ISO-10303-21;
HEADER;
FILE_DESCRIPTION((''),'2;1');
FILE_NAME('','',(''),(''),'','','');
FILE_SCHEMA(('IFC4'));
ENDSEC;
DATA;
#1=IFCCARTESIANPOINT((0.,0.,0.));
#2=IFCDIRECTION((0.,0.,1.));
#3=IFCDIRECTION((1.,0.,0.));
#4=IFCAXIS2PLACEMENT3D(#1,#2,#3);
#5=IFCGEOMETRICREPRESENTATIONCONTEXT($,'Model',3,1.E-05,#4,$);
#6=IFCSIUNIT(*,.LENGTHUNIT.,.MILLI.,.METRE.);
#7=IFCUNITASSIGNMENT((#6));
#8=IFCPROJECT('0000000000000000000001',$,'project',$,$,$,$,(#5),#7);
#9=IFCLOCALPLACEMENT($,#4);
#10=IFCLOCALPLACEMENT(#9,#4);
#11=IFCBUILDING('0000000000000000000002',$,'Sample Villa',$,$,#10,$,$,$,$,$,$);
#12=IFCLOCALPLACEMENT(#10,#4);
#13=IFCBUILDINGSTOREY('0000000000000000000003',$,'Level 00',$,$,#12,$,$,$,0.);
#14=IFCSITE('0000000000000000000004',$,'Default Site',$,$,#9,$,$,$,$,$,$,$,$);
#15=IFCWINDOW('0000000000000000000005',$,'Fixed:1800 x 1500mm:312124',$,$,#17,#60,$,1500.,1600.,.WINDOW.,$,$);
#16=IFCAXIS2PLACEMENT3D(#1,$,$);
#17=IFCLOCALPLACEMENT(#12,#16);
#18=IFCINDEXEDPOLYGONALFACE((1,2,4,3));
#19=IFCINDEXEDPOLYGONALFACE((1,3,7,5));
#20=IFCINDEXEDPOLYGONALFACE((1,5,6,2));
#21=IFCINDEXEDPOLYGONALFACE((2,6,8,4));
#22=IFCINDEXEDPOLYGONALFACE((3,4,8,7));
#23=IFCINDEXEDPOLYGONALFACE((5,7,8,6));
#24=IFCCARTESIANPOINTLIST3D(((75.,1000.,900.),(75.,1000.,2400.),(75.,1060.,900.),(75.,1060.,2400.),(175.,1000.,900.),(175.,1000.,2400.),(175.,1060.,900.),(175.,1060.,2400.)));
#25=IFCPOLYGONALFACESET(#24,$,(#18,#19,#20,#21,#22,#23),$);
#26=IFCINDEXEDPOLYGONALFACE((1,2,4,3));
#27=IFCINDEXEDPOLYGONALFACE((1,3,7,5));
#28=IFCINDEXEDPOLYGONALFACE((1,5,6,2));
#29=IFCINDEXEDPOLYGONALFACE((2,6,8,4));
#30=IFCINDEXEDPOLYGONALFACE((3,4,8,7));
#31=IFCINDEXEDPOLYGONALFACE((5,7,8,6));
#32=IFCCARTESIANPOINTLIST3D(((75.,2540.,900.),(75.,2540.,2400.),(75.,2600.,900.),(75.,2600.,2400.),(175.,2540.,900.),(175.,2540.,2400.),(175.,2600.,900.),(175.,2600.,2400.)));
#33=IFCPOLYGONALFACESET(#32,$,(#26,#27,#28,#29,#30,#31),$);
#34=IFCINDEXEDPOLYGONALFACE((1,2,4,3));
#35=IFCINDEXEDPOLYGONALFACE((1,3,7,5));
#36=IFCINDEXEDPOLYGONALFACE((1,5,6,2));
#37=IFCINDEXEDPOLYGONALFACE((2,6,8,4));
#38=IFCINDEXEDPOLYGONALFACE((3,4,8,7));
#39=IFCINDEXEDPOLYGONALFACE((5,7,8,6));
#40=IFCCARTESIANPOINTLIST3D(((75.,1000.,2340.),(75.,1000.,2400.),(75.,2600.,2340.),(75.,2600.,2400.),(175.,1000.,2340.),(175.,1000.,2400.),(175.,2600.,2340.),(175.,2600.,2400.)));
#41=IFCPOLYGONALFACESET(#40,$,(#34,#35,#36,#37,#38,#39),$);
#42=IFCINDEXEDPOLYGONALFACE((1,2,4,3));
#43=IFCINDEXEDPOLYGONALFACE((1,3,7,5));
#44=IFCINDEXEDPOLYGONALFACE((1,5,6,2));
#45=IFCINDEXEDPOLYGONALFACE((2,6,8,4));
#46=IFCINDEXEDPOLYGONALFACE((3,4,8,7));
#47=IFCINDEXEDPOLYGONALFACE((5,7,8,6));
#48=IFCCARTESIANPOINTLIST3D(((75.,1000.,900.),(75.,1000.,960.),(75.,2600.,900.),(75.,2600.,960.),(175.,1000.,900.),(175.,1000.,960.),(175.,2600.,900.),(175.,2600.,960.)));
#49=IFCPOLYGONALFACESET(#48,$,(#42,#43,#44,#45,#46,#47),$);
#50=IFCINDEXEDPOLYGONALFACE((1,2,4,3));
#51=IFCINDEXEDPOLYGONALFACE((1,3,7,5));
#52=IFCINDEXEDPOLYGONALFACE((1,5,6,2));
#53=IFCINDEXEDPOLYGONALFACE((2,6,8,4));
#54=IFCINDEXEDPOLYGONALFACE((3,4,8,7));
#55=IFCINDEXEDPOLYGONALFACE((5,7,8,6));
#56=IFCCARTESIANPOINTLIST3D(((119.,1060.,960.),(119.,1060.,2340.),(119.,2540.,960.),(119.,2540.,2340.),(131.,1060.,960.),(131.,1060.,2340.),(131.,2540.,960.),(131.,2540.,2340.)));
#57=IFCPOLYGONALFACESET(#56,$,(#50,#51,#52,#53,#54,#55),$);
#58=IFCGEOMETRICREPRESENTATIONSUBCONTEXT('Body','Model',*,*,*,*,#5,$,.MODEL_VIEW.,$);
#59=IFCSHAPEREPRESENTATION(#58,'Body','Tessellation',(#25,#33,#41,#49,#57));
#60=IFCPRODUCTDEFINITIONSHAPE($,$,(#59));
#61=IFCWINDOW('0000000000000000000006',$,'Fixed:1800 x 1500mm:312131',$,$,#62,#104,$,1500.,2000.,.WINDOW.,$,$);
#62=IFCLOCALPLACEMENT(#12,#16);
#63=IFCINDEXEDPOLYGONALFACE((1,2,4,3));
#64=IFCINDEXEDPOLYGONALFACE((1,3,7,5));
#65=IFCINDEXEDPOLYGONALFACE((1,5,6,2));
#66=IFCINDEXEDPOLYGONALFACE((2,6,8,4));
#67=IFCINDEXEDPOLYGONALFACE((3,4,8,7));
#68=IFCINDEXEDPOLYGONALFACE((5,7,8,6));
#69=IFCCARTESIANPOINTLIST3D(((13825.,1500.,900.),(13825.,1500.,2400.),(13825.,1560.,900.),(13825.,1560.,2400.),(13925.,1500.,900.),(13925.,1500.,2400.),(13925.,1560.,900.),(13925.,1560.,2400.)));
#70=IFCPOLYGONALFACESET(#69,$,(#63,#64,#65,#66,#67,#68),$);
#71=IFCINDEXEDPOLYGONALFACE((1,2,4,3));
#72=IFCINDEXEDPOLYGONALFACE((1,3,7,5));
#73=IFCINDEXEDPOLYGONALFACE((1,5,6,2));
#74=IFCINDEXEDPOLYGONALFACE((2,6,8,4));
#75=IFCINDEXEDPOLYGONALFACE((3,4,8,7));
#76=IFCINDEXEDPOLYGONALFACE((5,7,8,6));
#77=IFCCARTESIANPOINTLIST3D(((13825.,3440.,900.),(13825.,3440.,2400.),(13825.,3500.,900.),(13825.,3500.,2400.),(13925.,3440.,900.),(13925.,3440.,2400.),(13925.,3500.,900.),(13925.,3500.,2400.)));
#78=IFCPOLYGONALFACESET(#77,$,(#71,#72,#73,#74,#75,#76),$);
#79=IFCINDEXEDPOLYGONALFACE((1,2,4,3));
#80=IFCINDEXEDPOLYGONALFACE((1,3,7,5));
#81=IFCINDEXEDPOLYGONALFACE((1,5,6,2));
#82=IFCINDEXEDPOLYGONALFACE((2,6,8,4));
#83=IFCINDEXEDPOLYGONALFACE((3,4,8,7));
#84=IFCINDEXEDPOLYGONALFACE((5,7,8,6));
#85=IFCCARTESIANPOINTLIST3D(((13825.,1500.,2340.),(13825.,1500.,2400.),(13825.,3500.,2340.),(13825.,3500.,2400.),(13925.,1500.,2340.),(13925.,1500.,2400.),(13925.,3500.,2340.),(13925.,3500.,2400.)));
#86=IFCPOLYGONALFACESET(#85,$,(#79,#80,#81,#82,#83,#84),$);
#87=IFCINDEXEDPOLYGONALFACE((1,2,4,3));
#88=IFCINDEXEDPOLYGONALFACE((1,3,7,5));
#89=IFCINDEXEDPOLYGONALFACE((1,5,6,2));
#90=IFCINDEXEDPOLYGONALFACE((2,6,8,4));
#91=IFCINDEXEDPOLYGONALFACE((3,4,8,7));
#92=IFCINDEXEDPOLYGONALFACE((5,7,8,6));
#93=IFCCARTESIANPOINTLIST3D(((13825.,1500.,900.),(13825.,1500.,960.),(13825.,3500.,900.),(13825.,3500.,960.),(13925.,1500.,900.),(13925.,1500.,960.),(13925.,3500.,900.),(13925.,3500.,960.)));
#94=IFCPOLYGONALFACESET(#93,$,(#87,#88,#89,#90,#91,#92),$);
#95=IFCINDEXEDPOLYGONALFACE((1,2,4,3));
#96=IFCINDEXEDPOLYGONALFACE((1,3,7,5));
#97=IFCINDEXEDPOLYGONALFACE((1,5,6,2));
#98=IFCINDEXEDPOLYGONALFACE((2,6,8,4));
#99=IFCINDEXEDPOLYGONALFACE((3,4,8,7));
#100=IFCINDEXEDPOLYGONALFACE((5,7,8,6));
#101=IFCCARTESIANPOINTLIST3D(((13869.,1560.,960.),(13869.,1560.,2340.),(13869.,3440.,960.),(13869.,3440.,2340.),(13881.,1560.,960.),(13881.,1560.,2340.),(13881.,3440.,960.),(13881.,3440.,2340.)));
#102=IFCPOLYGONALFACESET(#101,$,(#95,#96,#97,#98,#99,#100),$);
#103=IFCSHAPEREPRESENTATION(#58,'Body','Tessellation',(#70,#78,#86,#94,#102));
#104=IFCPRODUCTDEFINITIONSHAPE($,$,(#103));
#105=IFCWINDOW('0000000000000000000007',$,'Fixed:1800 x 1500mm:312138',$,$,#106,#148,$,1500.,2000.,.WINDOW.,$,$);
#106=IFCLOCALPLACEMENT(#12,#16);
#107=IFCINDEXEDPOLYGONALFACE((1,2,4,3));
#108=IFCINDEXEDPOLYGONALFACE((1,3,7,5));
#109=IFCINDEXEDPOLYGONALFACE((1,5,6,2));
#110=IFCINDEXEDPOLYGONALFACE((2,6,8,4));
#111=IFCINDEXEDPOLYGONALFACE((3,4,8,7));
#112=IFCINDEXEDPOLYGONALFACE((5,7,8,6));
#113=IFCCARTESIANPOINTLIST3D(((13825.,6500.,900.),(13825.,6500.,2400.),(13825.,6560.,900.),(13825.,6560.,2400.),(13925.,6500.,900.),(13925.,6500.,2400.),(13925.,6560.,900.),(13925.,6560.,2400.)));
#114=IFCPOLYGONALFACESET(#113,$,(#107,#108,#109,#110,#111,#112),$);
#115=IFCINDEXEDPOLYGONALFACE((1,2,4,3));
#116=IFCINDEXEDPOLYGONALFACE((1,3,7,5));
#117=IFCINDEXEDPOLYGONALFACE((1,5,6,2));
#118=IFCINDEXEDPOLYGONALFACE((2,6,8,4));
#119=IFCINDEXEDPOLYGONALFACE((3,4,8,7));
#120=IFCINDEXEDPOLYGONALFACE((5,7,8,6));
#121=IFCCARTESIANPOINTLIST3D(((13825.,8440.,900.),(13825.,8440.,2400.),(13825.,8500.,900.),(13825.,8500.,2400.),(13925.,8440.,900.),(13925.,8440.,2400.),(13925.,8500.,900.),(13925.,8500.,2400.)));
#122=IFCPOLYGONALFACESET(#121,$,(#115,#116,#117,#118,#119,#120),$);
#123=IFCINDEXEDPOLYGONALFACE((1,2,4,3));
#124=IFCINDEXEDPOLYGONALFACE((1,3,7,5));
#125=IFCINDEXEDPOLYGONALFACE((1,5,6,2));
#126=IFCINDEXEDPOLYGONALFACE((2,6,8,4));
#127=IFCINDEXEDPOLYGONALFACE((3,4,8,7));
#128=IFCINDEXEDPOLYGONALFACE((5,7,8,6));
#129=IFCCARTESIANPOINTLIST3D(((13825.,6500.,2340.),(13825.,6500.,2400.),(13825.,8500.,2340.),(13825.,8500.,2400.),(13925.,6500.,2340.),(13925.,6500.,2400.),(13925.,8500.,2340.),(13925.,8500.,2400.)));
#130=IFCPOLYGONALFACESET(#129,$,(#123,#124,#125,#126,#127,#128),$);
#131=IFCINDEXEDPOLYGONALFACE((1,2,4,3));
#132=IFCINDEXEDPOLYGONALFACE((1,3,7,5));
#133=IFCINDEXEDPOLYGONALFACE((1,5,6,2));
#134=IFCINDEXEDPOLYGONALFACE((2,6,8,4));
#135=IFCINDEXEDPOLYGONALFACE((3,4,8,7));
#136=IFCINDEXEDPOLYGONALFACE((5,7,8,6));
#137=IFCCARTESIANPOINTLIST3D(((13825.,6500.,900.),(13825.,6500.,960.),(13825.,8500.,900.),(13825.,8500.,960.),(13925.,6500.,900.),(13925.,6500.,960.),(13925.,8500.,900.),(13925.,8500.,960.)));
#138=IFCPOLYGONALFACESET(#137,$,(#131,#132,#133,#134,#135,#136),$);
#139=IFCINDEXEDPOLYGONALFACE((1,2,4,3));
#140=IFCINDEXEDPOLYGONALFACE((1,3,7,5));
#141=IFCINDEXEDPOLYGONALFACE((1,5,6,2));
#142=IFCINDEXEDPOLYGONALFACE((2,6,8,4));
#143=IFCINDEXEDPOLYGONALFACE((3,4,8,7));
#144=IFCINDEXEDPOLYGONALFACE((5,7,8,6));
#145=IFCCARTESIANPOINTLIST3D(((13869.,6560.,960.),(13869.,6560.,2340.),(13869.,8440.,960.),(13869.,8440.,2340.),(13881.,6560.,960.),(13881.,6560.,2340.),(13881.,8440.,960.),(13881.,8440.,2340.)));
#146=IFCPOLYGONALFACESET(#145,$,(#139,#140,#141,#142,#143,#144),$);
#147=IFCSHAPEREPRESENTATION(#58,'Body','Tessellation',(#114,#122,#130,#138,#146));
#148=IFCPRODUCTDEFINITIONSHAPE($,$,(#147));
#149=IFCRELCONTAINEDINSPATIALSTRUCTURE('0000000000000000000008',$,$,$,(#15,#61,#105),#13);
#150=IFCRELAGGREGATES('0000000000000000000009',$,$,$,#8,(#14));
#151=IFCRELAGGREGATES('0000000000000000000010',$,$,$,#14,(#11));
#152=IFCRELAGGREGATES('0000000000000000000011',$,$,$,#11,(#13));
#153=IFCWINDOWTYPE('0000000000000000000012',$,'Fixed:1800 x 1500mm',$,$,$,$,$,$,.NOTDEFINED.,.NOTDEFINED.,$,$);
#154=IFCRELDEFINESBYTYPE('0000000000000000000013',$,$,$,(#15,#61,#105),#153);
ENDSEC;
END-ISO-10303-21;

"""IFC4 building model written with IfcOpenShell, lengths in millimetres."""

from ifc_helpers import new_model, si_unit, frame, frame_2d, origin_with_axes, place, context, subcontext, project, spatial, rectangle, extrude, type_object, element, save


model = new_model("IFC4")

# Units and contexts
model_context = context("Model", 3, precision=1e-05, world=origin_with_axes())
body_context = subcontext(model_context, "Body", "Model", "MODEL_VIEW")
ifc_project = project(units=[si_unit("LENGTHUNIT", "METRE", prefix="MILLI")], contexts=[model_context])

# Site, building, storey
site_placement = place(None, origin_with_axes())
site = spatial("IfcSite", under=ifc_project, at=site_placement, Name="Default Site")
building_placement = place(site_placement, origin_with_axes())
building = spatial("IfcBuilding", under=site, at=building_placement, Name="Sample Villa")
storey_placement = place(building_placement, origin_with_axes())
storey = spatial("IfcBuildingStorey", under=building, at=storey_placement, Name="Level 00", Elevation=0.0)

# Windows
window_type = type_object("IfcWindowType", Name="Fixed:1800 x 1500mm", PartitioningType="NOTDEFINED", PredefinedType="NOTDEFINED")
window_1_placement = place(storey_placement, origin_with_axes())
element("IfcWindow", 1, at=window_1_placement, inside=storey, type_object=window_type, Name="Fixed:1800 x 1500mm:312124", OverallHeight=1500.0, OverallWidth=1600.0, PredefinedType="WINDOW", context=body_context, shape_type="SweptSolid", body=[
    extrude(rectangle(XDim=100.0, YDim=60.0, at=frame_2d((50.0, 30.0))), frame((75.0, 1000.0, 900.0)), (0.0, 0.0, 1.0), 1500.0),
    extrude(rectangle(XDim=100.0, YDim=60.0, at=frame_2d((50.0, 30.0))), frame((75.0, 2540.0, 900.0)), (0.0, 0.0, 1.0), 1500.0),
    extrude(rectangle(XDim=100.0, YDim=1600.0, at=frame_2d((50.0, 800.0))), frame((75.0, 1000.0, 2340.0)), (0.0, 0.0, 1.0), 60.0),
    extrude(rectangle(XDim=100.0, YDim=1600.0, at=frame_2d((50.0, 800.0))), frame((75.0, 1000.0, 900.0)), (0.0, 0.0, 1.0), 60.0),
    extrude(rectangle(XDim=12.0, YDim=1480.0, at=frame_2d((6.0, 740.0))), frame((119.0, 1060.0, 960.0)), (0.0, 0.0, 1.0), 1380.0),
])
window_2_placement = place(storey_placement, origin_with_axes())
element("IfcWindow", 2, at=window_2_placement, inside=storey, type_object=window_type, Name="Fixed:1800 x 1500mm:312131", OverallHeight=1500.0, OverallWidth=2000.0, PredefinedType="WINDOW", context=body_context, shape_type="SweptSolid", body=[
    extrude(rectangle(XDim=100.0, YDim=60.0, at=frame_2d((50.0, 30.0))), frame((13825.0, 1500.0, 900.0)), (0.0, 0.0, 1.0), 1500.0),
    extrude(rectangle(XDim=100.0, YDim=60.0, at=frame_2d((50.0, 30.0))), frame((13825.0, 3440.0, 900.0)), (0.0, 0.0, 1.0), 1500.0),
    extrude(rectangle(XDim=100.0, YDim=2000.0, at=frame_2d((50.0, 1000.0))), frame((13825.0, 1500.0, 2340.0)), (0.0, 0.0, 1.0), 60.0),
    extrude(rectangle(XDim=100.0, YDim=2000.0, at=frame_2d((50.0, 1000.0))), frame((13825.0, 1500.0, 900.0)), (0.0, 0.0, 1.0), 60.0),
    extrude(rectangle(XDim=12.0, YDim=1880.0, at=frame_2d((6.0, 940.0))), frame((13869.0, 1560.0, 960.0)), (0.0, 0.0, 1.0), 1380.0),
])
window_3_placement = place(storey_placement, origin_with_axes())
element("IfcWindow", 3, at=window_3_placement, inside=storey, type_object=window_type, Name="Fixed:1800 x 1500mm:312138", OverallHeight=1500.0, OverallWidth=2000.0, PredefinedType="WINDOW", context=body_context, shape_type="SweptSolid", body=[
    extrude(rectangle(XDim=100.0, YDim=60.0, at=frame_2d((50.0, 30.0))), frame((13825.0, 6500.0, 900.0)), (0.0, 0.0, 1.0), 1500.0),
    extrude(rectangle(XDim=100.0, YDim=60.0, at=frame_2d((50.0, 30.0))), frame((13825.0, 8440.0, 900.0)), (0.0, 0.0, 1.0), 1500.0),
    extrude(rectangle(XDim=100.0, YDim=2000.0, at=frame_2d((50.0, 1000.0))), frame((13825.0, 6500.0, 2340.0)), (0.0, 0.0, 1.0), 60.0),
    extrude(rectangle(XDim=100.0, YDim=2000.0, at=frame_2d((50.0, 1000.0))), frame((13825.0, 6500.0, 900.0)), (0.0, 0.0, 1.0), 60.0),
    extrude(rectangle(XDim=12.0, YDim=1880.0, at=frame_2d((6.0, 940.0))), frame((13869.0, 6560.0, 960.0)), (0.0, 0.0, 1.0), 1380.0),
])

save(model, "model.ifc")
